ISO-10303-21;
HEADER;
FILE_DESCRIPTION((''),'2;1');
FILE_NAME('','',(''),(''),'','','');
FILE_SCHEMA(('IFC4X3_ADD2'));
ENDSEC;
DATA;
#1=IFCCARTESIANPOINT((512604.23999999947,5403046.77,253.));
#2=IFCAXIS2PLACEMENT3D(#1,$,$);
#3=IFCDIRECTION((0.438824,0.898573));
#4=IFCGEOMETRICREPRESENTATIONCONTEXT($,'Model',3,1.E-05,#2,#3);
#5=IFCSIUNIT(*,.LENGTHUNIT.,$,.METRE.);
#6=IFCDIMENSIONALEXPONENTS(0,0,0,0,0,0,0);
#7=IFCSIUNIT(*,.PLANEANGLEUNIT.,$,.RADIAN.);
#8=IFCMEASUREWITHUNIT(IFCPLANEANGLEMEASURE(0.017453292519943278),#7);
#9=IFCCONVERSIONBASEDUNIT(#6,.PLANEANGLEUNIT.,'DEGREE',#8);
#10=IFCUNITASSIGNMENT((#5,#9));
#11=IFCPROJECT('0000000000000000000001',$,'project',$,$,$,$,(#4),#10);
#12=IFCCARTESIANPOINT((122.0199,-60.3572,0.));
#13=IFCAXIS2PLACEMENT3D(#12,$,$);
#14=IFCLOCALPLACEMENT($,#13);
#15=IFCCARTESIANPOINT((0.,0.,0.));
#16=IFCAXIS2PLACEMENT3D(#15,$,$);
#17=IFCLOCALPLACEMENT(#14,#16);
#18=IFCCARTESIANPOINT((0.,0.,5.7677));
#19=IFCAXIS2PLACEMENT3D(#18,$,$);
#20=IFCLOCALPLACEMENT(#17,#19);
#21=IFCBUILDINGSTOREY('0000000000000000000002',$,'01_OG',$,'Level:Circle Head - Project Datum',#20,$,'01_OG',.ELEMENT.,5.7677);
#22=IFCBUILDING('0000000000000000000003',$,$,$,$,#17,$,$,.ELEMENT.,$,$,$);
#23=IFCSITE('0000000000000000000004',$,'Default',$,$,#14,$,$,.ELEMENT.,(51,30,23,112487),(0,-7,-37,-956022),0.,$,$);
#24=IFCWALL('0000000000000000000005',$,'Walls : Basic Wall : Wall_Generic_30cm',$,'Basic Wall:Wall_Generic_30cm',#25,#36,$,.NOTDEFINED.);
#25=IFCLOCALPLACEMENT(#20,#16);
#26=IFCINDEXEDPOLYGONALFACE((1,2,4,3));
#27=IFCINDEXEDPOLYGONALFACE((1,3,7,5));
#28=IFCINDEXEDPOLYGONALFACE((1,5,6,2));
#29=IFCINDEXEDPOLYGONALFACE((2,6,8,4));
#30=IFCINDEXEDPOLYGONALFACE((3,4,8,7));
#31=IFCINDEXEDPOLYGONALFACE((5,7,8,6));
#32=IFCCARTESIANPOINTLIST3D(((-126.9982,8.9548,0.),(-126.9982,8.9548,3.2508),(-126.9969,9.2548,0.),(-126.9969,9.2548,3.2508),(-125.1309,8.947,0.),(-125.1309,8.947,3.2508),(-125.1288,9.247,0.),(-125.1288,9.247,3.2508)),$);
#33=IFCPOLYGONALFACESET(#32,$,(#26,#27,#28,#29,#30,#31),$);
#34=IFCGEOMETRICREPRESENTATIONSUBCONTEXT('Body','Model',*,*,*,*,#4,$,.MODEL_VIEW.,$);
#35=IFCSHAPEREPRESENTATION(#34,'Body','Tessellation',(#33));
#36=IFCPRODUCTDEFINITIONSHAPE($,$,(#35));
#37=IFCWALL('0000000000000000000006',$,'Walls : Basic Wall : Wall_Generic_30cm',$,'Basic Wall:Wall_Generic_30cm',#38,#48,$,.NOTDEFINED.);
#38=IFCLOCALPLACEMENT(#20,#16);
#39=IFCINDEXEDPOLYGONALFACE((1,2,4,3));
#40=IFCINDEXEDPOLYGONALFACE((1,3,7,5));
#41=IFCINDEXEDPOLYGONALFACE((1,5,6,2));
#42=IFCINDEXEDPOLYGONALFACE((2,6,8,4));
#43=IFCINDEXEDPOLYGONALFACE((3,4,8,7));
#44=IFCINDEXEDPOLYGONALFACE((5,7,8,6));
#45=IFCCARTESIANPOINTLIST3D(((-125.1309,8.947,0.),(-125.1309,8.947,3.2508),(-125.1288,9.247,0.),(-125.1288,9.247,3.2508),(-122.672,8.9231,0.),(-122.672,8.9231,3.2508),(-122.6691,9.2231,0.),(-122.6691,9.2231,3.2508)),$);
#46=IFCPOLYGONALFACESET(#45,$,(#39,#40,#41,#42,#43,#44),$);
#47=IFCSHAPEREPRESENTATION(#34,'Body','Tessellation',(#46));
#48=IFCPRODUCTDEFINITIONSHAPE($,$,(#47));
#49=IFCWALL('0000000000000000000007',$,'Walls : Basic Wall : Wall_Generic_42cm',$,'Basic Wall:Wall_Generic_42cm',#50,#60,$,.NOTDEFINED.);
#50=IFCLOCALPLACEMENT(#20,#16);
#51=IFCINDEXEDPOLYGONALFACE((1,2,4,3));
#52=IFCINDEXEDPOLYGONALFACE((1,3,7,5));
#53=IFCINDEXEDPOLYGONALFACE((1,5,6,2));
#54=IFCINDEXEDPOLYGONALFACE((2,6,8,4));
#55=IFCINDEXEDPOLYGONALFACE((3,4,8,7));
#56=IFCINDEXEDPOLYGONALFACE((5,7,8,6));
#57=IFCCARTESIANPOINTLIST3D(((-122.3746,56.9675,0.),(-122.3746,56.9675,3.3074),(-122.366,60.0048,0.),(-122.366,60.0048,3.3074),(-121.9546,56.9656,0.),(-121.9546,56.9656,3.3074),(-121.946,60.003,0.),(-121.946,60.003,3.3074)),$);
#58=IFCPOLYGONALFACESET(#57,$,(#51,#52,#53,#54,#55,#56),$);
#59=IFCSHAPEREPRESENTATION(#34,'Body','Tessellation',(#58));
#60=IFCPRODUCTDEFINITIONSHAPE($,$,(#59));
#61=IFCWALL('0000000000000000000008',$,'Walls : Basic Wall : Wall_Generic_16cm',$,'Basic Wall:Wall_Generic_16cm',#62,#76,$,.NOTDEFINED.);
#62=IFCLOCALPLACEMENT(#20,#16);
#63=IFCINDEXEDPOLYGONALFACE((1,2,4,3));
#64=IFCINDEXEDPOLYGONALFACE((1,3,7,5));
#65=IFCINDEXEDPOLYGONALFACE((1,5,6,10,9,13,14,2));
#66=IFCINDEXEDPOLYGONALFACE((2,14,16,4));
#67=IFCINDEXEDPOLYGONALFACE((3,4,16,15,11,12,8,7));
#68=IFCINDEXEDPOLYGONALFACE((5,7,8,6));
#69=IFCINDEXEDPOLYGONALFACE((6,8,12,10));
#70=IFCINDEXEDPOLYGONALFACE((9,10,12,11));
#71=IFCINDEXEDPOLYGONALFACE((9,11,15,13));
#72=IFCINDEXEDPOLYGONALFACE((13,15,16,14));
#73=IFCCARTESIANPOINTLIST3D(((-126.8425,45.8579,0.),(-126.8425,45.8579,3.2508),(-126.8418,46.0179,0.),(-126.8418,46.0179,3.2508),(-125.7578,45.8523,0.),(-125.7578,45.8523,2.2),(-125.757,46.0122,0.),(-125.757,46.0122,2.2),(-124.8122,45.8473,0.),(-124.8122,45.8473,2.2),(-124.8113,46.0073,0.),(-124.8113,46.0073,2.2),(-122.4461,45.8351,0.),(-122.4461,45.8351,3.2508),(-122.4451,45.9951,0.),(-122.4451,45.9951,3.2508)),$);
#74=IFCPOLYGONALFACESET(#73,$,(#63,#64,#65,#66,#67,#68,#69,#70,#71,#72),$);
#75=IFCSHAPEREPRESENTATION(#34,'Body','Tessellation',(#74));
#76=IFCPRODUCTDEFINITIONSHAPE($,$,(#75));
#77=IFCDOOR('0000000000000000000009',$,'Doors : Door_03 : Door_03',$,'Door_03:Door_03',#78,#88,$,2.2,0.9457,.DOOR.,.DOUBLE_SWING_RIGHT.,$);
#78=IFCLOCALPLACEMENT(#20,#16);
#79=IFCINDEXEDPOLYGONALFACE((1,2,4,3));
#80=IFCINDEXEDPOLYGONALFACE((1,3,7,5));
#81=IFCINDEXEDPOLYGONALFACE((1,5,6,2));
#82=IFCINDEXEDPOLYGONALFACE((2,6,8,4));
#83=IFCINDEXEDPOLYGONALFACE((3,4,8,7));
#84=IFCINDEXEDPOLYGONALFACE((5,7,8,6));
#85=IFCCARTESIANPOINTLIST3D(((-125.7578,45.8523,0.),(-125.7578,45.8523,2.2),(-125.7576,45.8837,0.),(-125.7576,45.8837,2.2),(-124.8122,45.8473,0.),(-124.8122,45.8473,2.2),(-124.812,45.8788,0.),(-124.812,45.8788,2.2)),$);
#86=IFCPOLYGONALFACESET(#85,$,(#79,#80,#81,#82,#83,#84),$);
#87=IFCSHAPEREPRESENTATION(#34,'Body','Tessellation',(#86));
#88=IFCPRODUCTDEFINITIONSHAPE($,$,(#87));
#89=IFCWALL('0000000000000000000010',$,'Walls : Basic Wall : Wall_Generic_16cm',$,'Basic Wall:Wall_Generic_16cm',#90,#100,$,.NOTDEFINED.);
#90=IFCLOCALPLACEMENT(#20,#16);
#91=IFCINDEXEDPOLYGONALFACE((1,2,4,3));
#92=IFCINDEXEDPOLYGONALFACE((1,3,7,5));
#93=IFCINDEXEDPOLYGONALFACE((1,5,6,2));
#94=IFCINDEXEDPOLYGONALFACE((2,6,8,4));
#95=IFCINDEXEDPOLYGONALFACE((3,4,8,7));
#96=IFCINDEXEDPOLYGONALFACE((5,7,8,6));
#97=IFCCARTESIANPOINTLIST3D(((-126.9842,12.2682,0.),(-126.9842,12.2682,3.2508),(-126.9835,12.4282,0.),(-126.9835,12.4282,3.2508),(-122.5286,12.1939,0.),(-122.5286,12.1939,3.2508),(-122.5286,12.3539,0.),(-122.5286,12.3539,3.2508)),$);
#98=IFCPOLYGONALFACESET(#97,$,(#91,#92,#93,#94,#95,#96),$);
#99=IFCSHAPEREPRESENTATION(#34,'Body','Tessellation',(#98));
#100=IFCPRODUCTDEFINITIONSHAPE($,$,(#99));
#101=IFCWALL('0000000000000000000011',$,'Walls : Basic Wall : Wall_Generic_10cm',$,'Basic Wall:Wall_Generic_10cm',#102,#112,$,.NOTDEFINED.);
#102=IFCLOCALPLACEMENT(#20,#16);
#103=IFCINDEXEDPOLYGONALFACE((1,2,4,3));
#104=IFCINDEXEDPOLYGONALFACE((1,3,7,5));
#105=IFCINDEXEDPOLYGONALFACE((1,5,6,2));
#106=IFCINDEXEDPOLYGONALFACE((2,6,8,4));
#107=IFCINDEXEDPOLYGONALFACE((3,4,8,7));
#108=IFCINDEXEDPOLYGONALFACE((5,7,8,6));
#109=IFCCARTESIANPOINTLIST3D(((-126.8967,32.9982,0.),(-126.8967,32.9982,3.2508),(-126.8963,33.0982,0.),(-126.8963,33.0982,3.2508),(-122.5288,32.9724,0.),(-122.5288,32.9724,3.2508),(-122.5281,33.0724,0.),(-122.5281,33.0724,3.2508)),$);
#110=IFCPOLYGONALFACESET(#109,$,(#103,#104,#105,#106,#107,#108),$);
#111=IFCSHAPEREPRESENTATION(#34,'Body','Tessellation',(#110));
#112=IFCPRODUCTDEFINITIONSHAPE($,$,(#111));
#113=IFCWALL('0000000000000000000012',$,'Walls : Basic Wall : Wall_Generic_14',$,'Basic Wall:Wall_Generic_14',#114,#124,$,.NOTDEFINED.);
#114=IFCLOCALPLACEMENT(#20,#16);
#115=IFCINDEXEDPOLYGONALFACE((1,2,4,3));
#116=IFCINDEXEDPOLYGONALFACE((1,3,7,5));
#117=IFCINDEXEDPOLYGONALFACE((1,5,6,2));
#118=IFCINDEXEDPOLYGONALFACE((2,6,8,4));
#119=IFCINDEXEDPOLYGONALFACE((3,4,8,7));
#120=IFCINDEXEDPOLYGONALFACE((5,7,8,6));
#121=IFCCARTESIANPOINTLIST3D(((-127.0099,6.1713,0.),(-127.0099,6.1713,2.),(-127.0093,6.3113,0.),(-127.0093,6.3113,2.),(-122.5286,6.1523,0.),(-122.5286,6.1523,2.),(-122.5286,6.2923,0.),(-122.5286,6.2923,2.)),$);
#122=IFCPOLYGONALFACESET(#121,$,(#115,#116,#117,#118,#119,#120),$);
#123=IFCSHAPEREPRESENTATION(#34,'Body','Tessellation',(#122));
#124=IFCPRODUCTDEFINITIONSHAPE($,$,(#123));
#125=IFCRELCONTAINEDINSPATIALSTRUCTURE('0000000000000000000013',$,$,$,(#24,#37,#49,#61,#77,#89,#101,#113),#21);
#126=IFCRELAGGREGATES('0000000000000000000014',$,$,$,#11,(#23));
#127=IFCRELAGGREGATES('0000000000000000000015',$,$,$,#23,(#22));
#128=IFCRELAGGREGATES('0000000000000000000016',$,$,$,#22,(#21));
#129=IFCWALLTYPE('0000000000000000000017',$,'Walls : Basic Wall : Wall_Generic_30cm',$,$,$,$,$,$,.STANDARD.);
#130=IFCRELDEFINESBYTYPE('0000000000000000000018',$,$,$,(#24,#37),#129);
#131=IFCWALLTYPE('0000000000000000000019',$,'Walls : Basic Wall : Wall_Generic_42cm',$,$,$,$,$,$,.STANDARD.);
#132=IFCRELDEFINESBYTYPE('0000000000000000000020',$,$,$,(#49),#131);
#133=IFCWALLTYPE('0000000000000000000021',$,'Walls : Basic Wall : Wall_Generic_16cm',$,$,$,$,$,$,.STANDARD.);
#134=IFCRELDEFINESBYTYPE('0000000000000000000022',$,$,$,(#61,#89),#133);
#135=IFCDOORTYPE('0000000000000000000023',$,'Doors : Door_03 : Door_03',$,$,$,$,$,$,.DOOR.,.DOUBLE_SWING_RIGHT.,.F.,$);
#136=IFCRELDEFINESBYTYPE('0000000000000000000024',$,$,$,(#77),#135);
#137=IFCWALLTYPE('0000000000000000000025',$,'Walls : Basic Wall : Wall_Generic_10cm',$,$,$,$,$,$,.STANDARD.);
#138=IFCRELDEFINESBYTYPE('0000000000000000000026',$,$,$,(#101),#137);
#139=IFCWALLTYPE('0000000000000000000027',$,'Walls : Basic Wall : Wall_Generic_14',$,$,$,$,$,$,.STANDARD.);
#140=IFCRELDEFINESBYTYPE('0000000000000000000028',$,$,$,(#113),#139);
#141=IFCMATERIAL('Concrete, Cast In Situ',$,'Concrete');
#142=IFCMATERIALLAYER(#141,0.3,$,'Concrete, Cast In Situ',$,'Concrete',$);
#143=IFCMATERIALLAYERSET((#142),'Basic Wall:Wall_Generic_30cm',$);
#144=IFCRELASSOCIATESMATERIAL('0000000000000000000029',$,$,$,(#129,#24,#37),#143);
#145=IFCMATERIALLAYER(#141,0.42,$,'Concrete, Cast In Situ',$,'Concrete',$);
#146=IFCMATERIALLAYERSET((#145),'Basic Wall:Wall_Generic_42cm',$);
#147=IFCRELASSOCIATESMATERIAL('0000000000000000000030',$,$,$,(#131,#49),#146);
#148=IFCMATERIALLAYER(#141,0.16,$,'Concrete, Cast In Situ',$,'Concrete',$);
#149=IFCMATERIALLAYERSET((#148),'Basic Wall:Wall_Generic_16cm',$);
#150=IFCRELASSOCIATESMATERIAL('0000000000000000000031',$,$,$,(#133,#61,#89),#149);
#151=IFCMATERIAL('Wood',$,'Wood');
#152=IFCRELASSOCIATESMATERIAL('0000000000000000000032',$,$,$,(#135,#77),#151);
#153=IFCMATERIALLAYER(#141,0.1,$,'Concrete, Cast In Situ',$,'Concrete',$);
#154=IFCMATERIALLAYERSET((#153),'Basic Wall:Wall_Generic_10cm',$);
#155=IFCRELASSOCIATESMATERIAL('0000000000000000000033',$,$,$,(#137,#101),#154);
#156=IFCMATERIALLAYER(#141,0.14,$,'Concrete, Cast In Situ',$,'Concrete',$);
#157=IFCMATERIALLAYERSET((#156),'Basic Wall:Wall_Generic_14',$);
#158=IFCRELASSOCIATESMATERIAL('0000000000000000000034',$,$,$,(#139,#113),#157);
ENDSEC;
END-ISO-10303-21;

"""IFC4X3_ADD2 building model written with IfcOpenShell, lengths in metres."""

from ifc_helpers import new_model, entity, si_unit, converted_unit, direction, frame, frame_2d, origin, origin_2d_with_axis, place, context, subcontext, project, spatial, polyline, rectangle, outline, extrude, clip, bounded_halfspace, source, transform, mapped, material, layer, layer_set, type_object, type_shapes, element, fill, save


model = new_model("IFC4X3_ADD2")

# Units and contexts
model_context = context("Model", 3, precision=1e-05, world=frame((512604.23999999947, 5403046.77, 253.0)), true_north=direction((0.438824, 0.898573)))
body_context = subcontext(model_context, "Body", "Model", "MODEL_VIEW")
ifc_project = project(units=[si_unit("LENGTHUNIT", "METRE"), converted_unit("PLANEANGLEUNIT", "DEGREE", entity("IfcPlaneAngleMeasure", 0.017453292519943278), si_unit("PLANEANGLEUNIT", "RADIAN"), dimensions=[0, 0, 0, 0, 0, 0, 0])], contexts=[model_context])

# Site, building, storey
site_placement = place(None, frame((122.0199, -60.3572, 0.0)))
site = spatial("IfcSite", under=ifc_project, at=site_placement, Name="Default", CompositionType="ELEMENT", RefLatitude=(51, 30, 23, 112487), RefLongitude=(0, -7, -37, -956022), RefElevation=0.0)
building_placement = place(site_placement, origin())
building = spatial("IfcBuilding", under=site, at=building_placement, CompositionType="ELEMENT")
storey_placement = place(building_placement, frame((0.0, 0.0, 5.7677)))
storey = spatial("IfcBuildingStorey", under=building, at=storey_placement, Name="01_OG", ObjectType="Level:Circle Head - Project Datum", LongName="01_OG", CompositionType="ELEMENT", Elevation=5.7677)

# Walls
ifc_material_1 = material(Name="Concrete, Cast In Situ", Category="Concrete")
ifc_layer_1 = layer(ifc_material_1, 0.3, Name="Concrete, Cast In Situ", Category="Concrete")
ifc_layer_set_1 = layer_set([ifc_layer_1], Name="Basic Wall:Wall_Generic_30cm")
wall_type_1 = type_object("IfcWallType", Name="Walls : Basic Wall : Wall_Generic_30cm", PredefinedType="STANDARD", material=ifc_layer_set_1)
wall_1_placement = place(storey_placement, frame((-126.9976, 9.1048, 0.0), z_axis=(0.0, 0.0, 1.0), x_axis=(0.999991, -0.004154, 0.0)))
element("IfcWall", 1, at=wall_1_placement, inside=storey, type_object=wall_type_1, material=ifc_layer_set_1, Name="Walls : Basic Wall : Wall_Generic_30cm", ObjectType="Basic Wall:Wall_Generic_30cm", PredefinedType="NOTDEFINED", context=body_context, shape_type="Clipping", body=[
    clip(extrude(outline(polyline([(1.8673, -0.15), (1.8681, 0.15), (1.8492, 0.15), (1.7292, 0.15), (0.0, 0.15), (0.0, -0.15), (1.8673, -0.15)])), origin(), (0.0, 0.0, 1.0), 3.2508), bounded_halfspace(frame((0.0, -0.15, 3.2508), z_axis=(0.0, 0.0, -1.0), x_axis=(-0.00227, -0.999997, 0.0)), True, frame((0.0, -0.15, 3.2508)), polyline([(0.0, 0.0), (1.7113, 0.0), (1.8513, 0.0), (1.8673, 0.0), (1.8681, 0.3), (0.0, 0.3), (0.0, 0.0)]))),
])
wall_2_placement = place(storey_placement, frame((-125.1303, 9.097, 0.0), z_axis=(0.0, 0.0, 1.0), x_axis=(0.999953, -0.00971, 0.0)))
element("IfcWall", 2, at=wall_2_placement, inside=storey, type_object=wall_type_1, material=ifc_layer_set_1, Name="Walls : Basic Wall : Wall_Generic_30cm", ObjectType="Basic Wall:Wall_Generic_30cm", PredefinedType="NOTDEFINED", context=body_context, shape_type="Clipping", body=[
    clip(extrude(outline(polyline([(2.4598, -0.15), (2.4598, 0.0893), (2.4598, 0.15), (1.6798, 0.15), (1.6398, 0.15), (0.8398, 0.15), (0.7998, 0.15), (0.0, 0.15), (0.0008, -0.15), (2.4412, -0.15), (2.4598, -0.15)])), origin(), (0.0, 0.0, 1.0), 3.2508), bounded_halfspace(frame((0.0008, -0.15, 3.2508), z_axis=(0.0, 0.0, -1.0), x_axis=(0.003286, -0.999995, 0.0)), True, frame((0.0008, -0.15, 3.2508)), polyline([(0.0, 0.0), (2.459, 0.0), (2.459, 0.2393), (2.459, 0.3), (1.679, 0.3), (1.639, 0.3), (-0.0008, 0.3), (0.0, 0.0)]))),
])
ifc_layer_2 = layer(ifc_material_1, 0.42, Name="Concrete, Cast In Situ", Category="Concrete")
ifc_layer_set_2 = layer_set([ifc_layer_2], Name="Basic Wall:Wall_Generic_42cm")
wall_type_2 = type_object("IfcWallType", Name="Walls : Basic Wall : Wall_Generic_42cm", PredefinedType="STANDARD", material=ifc_layer_set_2)
wall_3_placement = place(storey_placement, frame((-122.156, 60.0042, 0.0), z_axis=(0.0, 0.0, 1.0), x_axis=(-0.002837, -0.999996, 0.0)))
element("IfcWall", 3, at=wall_3_placement, inside=storey, type_object=wall_type_2, material=ifc_layer_set_2, Name="Walls : Basic Wall : Wall_Generic_42cm", ObjectType="Basic Wall:Wall_Generic_42cm", PredefinedType="NOTDEFINED", context=body_context, shape_type="SweptSolid", body=[
    extrude(outline(polyline([(3.0373, -0.21), (3.038, 0.21), (0.0006, 0.21), (0.0, -0.21), (3.0373, -0.21)])), origin(), (0.0, 0.0, 1.0), 3.3074),
])

# Wall, opening, door
ifc_layer_3 = layer(ifc_material_1, 0.16, Name="Concrete, Cast In Situ", Category="Concrete")
ifc_layer_set_3 = layer_set([ifc_layer_3], Name="Basic Wall:Wall_Generic_16cm")
wall_type_3 = type_object("IfcWallType", Name="Walls : Basic Wall : Wall_Generic_16cm", PredefinedType="STANDARD", material=ifc_layer_set_3)
wall_4_placement = place(storey_placement, frame((-126.8422, 45.9379, 0.0), z_axis=(0.0, 0.0, 1.0), x_axis=(0.999987, -0.005186, 0.0)))
wall_4 = element("IfcWall", 4, at=wall_4_placement, inside=storey, type_object=wall_type_3, material=ifc_layer_set_3, Name="Walls : Basic Wall : Wall_Generic_16cm", ObjectType="Basic Wall:Wall_Generic_16cm", PredefinedType="NOTDEFINED", context=body_context, shape_type="Clipping", body=[
    clip(extrude(outline(polyline([(0.0002, -0.08), (4.3965, -0.08), (4.3967, 0.08), (0.0, 0.08), (0.0002, -0.08)])), origin(), (0.0, 0.0, 1.0), 3.2508), bounded_halfspace(frame((0.0002, -0.08, 3.2508), z_axis=(0.0, 0.0, -1.0), x_axis=(-0.001238, -0.999999, 0.0)), True, frame((0.0002, -0.08, 3.2508)), polyline([(0.0, 0.0), (4.3964, 0.0), (4.3966, 0.16), (-0.0002, 0.16), (0.0, 0.0)]))),
])
opening_placement = place(wall_4_placement, frame((127.0787, -45.2795, 0.0), z_axis=(0.0, 0.0, 1.0), x_axis=(0.999987, 0.005186, 0.0)))
opening = element("IfcOpeningElement", 5, at=opening_placement, cuts=wall_4, PredefinedType="OPENING", context=body_context, shape_type="SweptSolid", body=[
    extrude(rectangle(XDim=2.2, YDim=0.9457, at=frame_2d((0.0, 0.0), x_axis=(0.0, 1.0))), frame((-125.2851, 45.8313, 1.1), z_axis=(0.005186, 0.999987, 0.0), x_axis=(0.999987, -0.005186, 0.0)), (0.0, 0.0, 1.0), 0.1785),
])
ifc_material_2 = material(Name="Wood", Category="Wood")
door_type_1 = type_object("IfcDoorType", Name="Doors : Door_03 : Door_03", OperationType="DOUBLE_SWING_RIGHT", ParameterTakesPrecedence=False, PredefinedType="DOOR", material=ifc_material_2)
shared_shape_1 = source(origin(), body_context, "Body", "SweptSolid", [
    extrude(rectangle(XDim=0.0315, YDim=0.9457, at=origin_2d_with_axis()), frame((0.4728, 0.1443, 0.0), z_axis=(0.0, 0.0, 1.0), x_axis=(0.0, 1.0, 0.0)), (0.0, 0.0, 1.0), 2.2),
])
type_shapes(door_type_1, [shared_shape_1])
door_1_placement = place(opening_placement, frame((-124.8113, 46.0073, 0.0), z_axis=(0.0, 0.0, 1.0), x_axis=(-0.999987, 0.005186, 0.0)))
door_1 = element("IfcDoor", 6, at=door_1_placement, inside=storey, type_object=door_type_1, material=ifc_material_2, Name="Doors : Door_03 : Door_03", ObjectType="Door_03:Door_03", OperationType="DOUBLE_SWING_RIGHT", OverallHeight=2.2, OverallWidth=0.9457, PredefinedType="DOOR", context=body_context, shape_type="MappedRepresentation", body=[
    mapped(shared_shape_1, transform((0.0, 0.0, 0.0), scale=1.0)),
])
fill(opening, door_1)

# Walls
wall_5_placement = place(storey_placement, frame((-126.9849, 12.3482, 0.0), z_axis=(0.0, 0.0, 1.0), x_axis=(0.999861, -0.016678, 0.0)))
element("IfcWall", 7, at=wall_5_placement, inside=storey, type_object=wall_type_3, material=ifc_layer_set_3, Name="Walls : Basic Wall : Wall_Generic_16cm", ObjectType="Basic Wall:Wall_Generic_16cm", PredefinedType="NOTDEFINED", context=body_context, shape_type="Clipping", body=[
    clip(extrude(outline(polyline([(4.4582, -0.08), (4.4555, 0.08), (0.0, 0.08), (0.002, -0.08), (1.7187, -0.08), (1.8387, -0.08), (4.4582, -0.08)])), origin(), (0.0, 0.0, 1.0), 3.2508), bounded_halfspace(frame((0.002, -0.08, 3.2508), z_axis=(0.0, 0.0, -1.0), x_axis=(0.010254, -0.999947, 0.0)), True, frame((0.002, -0.08, 3.2508)), polyline([(0.0, 0.0), (4.4562, 0.0), (4.4535, 0.16), (-0.002, 0.16), (0.0, 0.0)]))),
])
ifc_layer_4 = layer(ifc_material_1, 0.1, Name="Concrete, Cast In Situ", Category="Concrete")
ifc_layer_set_4 = layer_set([ifc_layer_4], Name="Basic Wall:Wall_Generic_10cm")
wall_type_4 = type_object("IfcWallType", Name="Walls : Basic Wall : Wall_Generic_10cm", PredefinedType="STANDARD", material=ifc_layer_set_4)
wall_6_placement = place(storey_placement, frame((-126.8966, 33.0482, 0.0), z_axis=(0.0, 0.0, 1.0), x_axis=(0.999983, -0.005901, 0.0)))
element("IfcWall", 8, at=wall_6_placement, inside=storey, type_object=wall_type_4, material=ifc_layer_set_4, Name="Walls : Basic Wall : Wall_Generic_10cm", ObjectType="Basic Wall:Wall_Generic_10cm", PredefinedType="NOTDEFINED", context=body_context, shape_type="Clipping", body=[
    clip(extrude(outline(polyline([(4.3682, -0.05), (4.3683, 0.05), (0.0, 0.05), (0.0002, -0.05), (4.3682, -0.05)])), origin(), (0.0, 0.0, 1.0), 3.2508), bounded_halfspace(frame((0.0002, -0.05, 3.2508), z_axis=(0.0, 0.0, -1.0), x_axis=(-0.000523, -1.0, 0.0)), True, frame((0.0002, -0.05, 3.2508)), polyline([(0.0, 0.0), (4.368, 0.0), (4.3681, 0.1), (-0.0002, 0.1), (0.0, 0.0)]))),
])
ifc_layer_5 = layer(ifc_material_1, 0.14, Name="Concrete, Cast In Situ", Category="Concrete")
ifc_layer_set_5 = layer_set([ifc_layer_5], Name="Basic Wall:Wall_Generic_14")
wall_type_5 = type_object("IfcWallType", Name="Walls : Basic Wall : Wall_Generic_14", PredefinedType="STANDARD", material=ifc_layer_set_5)
wall_7_placement = place(storey_placement, frame((-127.0096, 6.2413, 0.0), z_axis=(0.0, 0.0, 1.0), x_axis=(0.999991, -0.004219, 0.0)))
element("IfcWall", 9, at=wall_7_placement, inside=storey, type_object=wall_type_5, material=ifc_layer_set_5, Name="Walls : Basic Wall : Wall_Generic_14", ObjectType="Basic Wall:Wall_Generic_14", PredefinedType="NOTDEFINED", context=body_context, shape_type="SweptSolid", body=[
    extrude(outline(polyline([(4.4814, -0.07), (4.4808, 0.07), (0.0, 0.07), (0.0, -0.07), (4.4814, -0.07)])), origin(), (0.0, 0.0, 1.0), 2.0),
])

save(model, "model.ifc")
